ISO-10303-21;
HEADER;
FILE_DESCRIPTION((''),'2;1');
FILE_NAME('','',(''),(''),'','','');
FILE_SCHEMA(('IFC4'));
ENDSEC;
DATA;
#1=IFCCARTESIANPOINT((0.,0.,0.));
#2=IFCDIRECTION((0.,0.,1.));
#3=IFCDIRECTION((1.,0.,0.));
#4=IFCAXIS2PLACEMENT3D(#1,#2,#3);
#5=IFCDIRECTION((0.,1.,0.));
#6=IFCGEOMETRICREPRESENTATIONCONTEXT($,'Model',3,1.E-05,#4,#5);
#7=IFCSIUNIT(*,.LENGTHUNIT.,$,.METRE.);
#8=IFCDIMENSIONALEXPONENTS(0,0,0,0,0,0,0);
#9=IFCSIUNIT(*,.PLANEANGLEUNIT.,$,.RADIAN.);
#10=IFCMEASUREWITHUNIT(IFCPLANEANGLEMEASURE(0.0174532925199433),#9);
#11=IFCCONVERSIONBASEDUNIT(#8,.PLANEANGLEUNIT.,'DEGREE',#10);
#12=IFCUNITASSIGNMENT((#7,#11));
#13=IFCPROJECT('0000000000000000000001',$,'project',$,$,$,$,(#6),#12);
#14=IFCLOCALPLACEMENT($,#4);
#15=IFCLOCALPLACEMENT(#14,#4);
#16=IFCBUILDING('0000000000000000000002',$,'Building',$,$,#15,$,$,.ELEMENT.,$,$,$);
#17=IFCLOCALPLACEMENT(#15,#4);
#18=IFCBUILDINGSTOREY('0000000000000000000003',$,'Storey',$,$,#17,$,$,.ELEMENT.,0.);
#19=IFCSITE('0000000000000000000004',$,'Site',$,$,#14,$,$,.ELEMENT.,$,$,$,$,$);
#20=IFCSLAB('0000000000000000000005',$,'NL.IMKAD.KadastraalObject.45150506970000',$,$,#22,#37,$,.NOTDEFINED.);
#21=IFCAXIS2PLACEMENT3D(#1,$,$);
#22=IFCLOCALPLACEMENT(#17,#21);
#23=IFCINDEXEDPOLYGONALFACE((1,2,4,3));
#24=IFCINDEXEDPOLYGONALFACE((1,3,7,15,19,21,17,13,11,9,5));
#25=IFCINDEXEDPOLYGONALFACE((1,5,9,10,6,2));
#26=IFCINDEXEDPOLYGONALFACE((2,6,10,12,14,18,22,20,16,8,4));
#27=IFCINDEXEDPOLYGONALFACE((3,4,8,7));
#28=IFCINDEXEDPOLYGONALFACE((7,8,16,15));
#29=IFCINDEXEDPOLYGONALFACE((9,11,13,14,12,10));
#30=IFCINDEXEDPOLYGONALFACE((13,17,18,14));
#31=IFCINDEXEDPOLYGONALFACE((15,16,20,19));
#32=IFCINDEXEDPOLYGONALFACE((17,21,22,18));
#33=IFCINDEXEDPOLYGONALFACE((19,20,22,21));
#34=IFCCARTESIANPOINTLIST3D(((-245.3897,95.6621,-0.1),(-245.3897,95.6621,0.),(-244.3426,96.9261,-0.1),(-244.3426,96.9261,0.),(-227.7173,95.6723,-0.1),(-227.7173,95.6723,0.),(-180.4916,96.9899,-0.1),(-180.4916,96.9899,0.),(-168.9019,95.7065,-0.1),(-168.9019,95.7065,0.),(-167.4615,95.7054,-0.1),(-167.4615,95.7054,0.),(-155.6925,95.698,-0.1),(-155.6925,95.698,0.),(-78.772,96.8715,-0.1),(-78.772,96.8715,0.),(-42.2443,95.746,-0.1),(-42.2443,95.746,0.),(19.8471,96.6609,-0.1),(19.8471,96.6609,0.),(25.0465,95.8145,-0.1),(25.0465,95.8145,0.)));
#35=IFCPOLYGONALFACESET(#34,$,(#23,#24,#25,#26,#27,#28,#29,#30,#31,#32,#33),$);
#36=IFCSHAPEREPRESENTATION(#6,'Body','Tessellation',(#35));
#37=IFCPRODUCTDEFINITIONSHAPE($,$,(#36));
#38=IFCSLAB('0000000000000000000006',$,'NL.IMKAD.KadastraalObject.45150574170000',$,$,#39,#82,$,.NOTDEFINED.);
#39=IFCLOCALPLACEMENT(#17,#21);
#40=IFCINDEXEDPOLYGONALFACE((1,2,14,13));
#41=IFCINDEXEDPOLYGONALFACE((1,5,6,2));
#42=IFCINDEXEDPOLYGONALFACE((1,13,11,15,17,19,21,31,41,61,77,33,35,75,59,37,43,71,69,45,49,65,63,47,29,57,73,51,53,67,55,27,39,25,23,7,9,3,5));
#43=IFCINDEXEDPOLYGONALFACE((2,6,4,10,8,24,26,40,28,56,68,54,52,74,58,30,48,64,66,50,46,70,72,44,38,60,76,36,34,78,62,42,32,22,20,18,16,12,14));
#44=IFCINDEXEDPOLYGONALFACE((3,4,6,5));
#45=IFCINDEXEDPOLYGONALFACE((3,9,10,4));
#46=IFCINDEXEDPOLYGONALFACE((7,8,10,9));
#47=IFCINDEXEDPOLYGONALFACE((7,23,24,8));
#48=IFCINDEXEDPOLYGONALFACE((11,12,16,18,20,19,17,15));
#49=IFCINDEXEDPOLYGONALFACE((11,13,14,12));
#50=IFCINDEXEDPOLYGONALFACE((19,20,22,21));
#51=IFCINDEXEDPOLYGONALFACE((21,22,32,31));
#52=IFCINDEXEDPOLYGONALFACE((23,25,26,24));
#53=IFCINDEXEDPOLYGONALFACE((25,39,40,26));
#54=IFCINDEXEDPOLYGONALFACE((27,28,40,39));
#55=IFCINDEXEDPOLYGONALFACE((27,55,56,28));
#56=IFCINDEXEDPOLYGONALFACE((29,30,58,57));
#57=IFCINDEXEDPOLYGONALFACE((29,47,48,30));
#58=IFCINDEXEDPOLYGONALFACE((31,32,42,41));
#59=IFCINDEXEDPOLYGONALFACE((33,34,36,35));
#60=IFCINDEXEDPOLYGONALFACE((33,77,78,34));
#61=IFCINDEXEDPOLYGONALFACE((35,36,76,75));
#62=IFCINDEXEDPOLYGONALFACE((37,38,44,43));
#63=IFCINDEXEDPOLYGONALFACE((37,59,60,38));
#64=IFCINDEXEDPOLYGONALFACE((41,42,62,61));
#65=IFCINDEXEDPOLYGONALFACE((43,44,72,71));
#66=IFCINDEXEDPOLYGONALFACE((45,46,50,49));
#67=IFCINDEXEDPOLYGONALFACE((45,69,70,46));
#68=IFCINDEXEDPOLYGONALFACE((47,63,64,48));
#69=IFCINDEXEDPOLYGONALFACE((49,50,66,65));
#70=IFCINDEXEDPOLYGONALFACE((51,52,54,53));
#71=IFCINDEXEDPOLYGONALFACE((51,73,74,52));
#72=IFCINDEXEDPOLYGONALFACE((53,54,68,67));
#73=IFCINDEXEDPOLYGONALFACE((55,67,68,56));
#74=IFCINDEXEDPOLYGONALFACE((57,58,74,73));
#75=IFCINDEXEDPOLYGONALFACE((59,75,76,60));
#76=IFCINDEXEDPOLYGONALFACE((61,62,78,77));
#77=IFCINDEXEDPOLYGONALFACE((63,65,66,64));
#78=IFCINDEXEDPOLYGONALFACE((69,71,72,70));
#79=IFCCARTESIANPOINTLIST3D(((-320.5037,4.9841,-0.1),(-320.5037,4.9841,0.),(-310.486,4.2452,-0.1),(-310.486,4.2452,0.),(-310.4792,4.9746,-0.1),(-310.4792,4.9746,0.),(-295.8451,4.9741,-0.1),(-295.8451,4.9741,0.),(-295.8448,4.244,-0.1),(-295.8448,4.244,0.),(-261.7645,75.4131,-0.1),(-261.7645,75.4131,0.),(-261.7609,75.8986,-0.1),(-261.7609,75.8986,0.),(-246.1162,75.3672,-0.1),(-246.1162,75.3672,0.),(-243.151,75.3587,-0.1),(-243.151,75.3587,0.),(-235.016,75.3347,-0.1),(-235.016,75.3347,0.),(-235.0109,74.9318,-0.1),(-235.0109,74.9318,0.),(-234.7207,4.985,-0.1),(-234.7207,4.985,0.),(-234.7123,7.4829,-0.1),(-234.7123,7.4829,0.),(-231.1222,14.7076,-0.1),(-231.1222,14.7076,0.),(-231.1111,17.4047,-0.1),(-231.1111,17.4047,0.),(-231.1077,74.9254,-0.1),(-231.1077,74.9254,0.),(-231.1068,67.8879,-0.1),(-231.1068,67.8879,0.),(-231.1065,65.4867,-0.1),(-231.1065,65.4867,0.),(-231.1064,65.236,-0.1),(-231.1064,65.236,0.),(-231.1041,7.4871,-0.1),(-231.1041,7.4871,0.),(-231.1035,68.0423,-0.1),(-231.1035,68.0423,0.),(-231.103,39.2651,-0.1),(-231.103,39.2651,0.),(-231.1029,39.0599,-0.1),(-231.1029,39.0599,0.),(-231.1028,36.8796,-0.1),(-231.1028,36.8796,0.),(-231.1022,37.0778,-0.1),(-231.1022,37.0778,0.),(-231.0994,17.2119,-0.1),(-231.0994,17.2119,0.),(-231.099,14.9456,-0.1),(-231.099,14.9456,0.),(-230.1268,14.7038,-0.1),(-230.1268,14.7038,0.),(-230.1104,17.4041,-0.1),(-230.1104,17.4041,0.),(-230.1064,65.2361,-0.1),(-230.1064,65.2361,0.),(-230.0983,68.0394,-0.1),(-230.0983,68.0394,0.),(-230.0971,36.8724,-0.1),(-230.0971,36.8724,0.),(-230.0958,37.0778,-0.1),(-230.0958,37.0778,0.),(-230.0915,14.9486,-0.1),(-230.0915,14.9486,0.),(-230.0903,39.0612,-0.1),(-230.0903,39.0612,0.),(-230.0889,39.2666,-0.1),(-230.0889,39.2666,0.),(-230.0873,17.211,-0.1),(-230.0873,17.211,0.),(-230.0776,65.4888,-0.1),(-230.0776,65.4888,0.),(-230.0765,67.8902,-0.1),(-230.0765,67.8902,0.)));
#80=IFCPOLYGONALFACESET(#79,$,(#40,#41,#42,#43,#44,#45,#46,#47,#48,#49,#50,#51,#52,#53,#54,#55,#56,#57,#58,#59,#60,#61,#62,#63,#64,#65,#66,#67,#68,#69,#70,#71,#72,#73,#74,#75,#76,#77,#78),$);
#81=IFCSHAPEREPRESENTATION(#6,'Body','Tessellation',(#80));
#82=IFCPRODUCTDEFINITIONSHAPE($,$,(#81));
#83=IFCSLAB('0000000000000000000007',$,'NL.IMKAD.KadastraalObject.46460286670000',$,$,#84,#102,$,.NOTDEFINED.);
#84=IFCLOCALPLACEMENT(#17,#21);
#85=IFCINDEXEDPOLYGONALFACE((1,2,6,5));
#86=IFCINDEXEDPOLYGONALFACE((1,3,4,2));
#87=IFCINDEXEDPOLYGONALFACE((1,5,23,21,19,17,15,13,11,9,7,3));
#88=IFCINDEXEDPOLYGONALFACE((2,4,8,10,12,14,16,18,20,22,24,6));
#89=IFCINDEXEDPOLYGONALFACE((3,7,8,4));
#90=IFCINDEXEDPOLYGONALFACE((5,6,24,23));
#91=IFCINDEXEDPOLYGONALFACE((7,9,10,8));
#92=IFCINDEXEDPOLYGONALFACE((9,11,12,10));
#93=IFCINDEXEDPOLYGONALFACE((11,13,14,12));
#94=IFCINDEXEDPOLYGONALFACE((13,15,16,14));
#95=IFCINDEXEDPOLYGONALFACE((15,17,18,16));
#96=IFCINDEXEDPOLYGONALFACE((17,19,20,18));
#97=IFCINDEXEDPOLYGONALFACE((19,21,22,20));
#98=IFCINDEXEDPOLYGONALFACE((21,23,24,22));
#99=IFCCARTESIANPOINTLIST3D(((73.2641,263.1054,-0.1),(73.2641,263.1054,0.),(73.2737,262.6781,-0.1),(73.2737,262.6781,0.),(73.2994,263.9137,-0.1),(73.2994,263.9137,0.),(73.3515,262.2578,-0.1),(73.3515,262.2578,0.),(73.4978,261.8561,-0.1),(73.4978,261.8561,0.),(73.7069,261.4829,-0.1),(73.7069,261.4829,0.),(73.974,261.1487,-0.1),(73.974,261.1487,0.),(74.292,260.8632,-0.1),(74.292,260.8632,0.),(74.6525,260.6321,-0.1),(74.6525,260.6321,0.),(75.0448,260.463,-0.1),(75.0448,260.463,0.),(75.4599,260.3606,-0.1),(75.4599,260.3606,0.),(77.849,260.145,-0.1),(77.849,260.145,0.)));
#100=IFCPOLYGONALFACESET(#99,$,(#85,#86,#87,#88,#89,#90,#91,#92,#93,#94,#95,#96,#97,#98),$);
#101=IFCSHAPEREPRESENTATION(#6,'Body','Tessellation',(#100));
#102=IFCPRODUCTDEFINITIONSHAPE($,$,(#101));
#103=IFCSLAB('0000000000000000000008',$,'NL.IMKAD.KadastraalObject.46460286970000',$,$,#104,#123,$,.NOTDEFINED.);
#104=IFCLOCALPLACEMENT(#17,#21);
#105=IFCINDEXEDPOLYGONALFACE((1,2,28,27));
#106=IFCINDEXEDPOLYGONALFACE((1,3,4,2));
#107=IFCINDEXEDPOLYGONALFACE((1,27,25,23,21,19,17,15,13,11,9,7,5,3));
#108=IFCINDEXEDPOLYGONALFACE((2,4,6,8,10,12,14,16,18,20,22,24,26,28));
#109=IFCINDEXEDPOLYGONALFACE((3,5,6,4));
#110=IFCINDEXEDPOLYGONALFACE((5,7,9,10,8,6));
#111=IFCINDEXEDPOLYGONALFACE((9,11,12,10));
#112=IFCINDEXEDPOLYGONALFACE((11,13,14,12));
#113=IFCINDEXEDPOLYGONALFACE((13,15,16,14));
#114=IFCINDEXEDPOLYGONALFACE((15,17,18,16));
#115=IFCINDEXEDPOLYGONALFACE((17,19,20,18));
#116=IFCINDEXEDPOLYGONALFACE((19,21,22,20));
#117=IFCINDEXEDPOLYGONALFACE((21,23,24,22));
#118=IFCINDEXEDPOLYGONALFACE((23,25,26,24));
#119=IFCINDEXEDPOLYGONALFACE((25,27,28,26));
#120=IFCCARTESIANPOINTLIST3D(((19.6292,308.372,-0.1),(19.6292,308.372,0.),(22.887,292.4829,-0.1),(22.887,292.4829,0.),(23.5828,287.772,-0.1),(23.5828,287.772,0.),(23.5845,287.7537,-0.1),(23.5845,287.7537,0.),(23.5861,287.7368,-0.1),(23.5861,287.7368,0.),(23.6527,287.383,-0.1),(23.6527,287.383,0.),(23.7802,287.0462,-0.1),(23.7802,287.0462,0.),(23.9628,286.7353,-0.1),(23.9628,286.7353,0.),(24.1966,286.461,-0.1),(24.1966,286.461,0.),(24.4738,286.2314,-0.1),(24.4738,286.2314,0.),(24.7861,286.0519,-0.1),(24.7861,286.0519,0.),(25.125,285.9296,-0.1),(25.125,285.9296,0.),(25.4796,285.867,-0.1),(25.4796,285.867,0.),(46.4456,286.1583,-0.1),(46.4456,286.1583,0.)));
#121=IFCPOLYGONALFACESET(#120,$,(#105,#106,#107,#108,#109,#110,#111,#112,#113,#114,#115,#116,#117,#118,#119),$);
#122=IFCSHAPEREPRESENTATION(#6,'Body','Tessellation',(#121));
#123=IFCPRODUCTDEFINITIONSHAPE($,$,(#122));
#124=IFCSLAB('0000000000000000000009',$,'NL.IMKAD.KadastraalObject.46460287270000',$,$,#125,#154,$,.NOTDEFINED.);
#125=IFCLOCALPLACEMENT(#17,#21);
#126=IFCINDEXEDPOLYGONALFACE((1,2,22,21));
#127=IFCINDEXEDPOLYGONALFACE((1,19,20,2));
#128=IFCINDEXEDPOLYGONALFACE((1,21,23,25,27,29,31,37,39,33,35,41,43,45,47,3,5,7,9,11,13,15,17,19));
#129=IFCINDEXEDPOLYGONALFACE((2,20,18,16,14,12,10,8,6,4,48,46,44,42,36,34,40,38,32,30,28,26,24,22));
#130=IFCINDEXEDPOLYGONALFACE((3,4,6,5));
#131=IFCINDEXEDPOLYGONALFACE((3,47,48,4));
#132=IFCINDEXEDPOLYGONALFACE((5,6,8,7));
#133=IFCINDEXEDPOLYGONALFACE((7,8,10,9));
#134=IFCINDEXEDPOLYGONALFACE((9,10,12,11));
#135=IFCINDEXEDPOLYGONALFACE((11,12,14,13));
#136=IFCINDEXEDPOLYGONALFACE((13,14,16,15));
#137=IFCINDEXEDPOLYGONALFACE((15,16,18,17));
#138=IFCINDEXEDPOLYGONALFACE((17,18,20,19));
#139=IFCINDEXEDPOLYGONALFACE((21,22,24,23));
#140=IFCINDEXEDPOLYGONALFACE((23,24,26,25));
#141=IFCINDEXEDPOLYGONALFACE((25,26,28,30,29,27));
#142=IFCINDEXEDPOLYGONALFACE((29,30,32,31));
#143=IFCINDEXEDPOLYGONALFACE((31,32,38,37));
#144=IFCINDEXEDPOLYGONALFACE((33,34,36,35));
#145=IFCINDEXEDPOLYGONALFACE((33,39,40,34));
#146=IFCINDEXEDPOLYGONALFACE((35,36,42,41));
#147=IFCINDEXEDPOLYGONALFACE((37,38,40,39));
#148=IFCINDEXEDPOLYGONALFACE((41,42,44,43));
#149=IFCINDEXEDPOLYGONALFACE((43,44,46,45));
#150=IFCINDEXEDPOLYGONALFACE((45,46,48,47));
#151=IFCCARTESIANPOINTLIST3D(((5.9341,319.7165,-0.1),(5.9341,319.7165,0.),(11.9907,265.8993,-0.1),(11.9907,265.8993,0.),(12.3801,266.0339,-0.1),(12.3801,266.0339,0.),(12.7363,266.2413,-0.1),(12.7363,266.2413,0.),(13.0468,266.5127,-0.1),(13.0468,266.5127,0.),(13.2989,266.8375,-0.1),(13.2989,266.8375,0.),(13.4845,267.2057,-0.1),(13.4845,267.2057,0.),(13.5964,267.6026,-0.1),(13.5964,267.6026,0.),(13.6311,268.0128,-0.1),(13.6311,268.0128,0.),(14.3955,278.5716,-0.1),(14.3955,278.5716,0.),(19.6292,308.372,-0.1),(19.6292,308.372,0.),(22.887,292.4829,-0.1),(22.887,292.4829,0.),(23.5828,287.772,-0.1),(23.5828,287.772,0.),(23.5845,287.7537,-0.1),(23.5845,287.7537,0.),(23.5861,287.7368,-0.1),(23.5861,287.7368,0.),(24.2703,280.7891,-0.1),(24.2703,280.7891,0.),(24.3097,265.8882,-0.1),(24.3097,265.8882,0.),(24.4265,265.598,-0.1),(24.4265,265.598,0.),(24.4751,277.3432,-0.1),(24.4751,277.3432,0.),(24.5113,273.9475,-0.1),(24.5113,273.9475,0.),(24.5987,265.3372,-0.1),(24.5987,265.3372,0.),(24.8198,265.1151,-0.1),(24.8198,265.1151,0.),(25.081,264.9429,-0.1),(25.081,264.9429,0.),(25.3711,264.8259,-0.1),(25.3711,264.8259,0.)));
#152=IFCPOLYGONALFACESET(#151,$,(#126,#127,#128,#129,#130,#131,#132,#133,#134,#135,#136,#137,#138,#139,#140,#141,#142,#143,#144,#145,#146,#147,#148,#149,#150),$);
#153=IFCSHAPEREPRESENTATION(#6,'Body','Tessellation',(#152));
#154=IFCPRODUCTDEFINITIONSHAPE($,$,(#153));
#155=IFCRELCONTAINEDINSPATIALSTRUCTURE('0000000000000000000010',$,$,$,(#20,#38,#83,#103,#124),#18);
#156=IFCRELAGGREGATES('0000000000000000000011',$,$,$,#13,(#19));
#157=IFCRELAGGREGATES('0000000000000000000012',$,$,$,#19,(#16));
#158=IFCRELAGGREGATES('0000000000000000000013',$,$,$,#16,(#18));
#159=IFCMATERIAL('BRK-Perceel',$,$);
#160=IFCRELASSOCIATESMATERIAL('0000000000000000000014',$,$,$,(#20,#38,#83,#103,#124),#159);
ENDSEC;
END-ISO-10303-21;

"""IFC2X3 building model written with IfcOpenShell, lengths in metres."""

from ifc_helpers import new_model, entity, si_unit, converted_unit, direction, frame, origin_with_axes, place, context, project, spatial, polyline, outline, extrude, material, element, save


model = new_model("IFC2X3")

# Units and contexts
model_context = context("Model", 3, precision=1e-05, world=origin_with_axes(), true_north=direction((0.0, 1.0, 0.0)))
ifc_project = project(units=[si_unit("LENGTHUNIT", "METRE"), converted_unit("PLANEANGLEUNIT", "DEGREE", entity("IfcPlaneAngleMeasure", 0.0174532925199433), si_unit("PLANEANGLEUNIT", "RADIAN"), dimensions=[0, 0, 0, 0, 0, 0, 0])], contexts=[model_context])

# Site, building, storey
site_placement = place(None, origin_with_axes())
site = spatial("IfcSite", under=ifc_project, at=site_placement, Name="Site", CompositionType="ELEMENT")
building_placement = place(site_placement, origin_with_axes())
building = spatial("IfcBuilding", under=site, at=building_placement, Name="Building", CompositionType="ELEMENT")
storey_placement = place(building_placement, origin_with_axes())
storey = spatial("IfcBuildingStorey", under=building, at=storey_placement, Name="Storey", CompositionType="ELEMENT", Elevation=0.0)

# Slabs
ifc_material = material(Name="BRK-Perceel")
slab_1_placement = place(storey_placement, frame((0.0, 0.0, -0.1), z_axis=(0.0, 0.0, 1.0), x_axis=(1.0, 0.0, 0.0)))
element("IfcSlab", 1, at=slab_1_placement, inside=storey, material=ifc_material, Name="NL.IMKAD.KadastraalObject.45150506970000", PredefinedType="NOTDEFINED", context=model_context, shape_type="SweptSolid", body=[
    extrude(outline(polyline([(-180.4916, 96.9899), (-78.772, 96.8715), (19.8471, 96.6609), (25.0465, 95.8145), (-42.2443, 95.746), (-155.6925, 95.698), (-167.4615, 95.7054), (-168.9019, 95.7065), (-227.7173, 95.6723), (-245.3897, 95.6621), (-244.3426, 96.9261), (-180.4916, 96.9899)])), origin_with_axes(), (0.0, 0.0, 1.0), 0.1),
])
slab_2_placement = place(storey_placement, frame((0.0, 0.0, -0.1), z_axis=(0.0, 0.0, 1.0), x_axis=(1.0, 0.0, 0.0)))
element("IfcSlab", 2, at=slab_2_placement, inside=storey, material=ifc_material, Name="NL.IMKAD.KadastraalObject.45150574170000", PredefinedType="NOTDEFINED", context=model_context, shape_type="SweptSolid", body=[
    extrude(outline(polyline([(-261.7645, 75.4131), (-246.1162, 75.3672), (-243.151, 75.3587), (-235.016, 75.3347), (-235.0109, 74.9318), (-231.1077, 74.9254), (-231.1035, 68.0423), (-230.0983, 68.0394), (-230.0765, 67.8902), (-231.1068, 67.8879), (-231.1065, 65.4867), (-230.0776, 65.4888), (-230.1064, 65.2361), (-231.1064, 65.236), (-231.103, 39.2651), (-230.0889, 39.2666), (-230.0903, 39.0612), (-231.1029, 39.0599), (-231.1022, 37.0778), (-230.0958, 37.0778), (-230.0971, 36.8724), (-231.1028, 36.8796), (-231.1111, 17.4047), (-230.1104, 17.4041), (-230.0873, 17.211), (-231.0994, 17.2119), (-231.099, 14.9456), (-230.0915, 14.9486), (-230.1268, 14.7038), (-231.1222, 14.7076), (-231.1041, 7.4871), (-234.7123, 7.4829), (-234.7207, 4.985), (-295.8451, 4.9741), (-295.8448, 4.244), (-310.486, 4.2452), (-310.4792, 4.9746), (-320.5037, 4.9841), (-261.7609, 75.8986), (-261.7645, 75.4131)])), origin_with_axes(), (0.0, 0.0, 1.0), 0.1),
])
slab_3_placement = place(storey_placement, frame((0.0, 0.0, -0.1), z_axis=(0.0, 0.0, 1.0), x_axis=(1.0, 0.0, 0.0)))
element("IfcSlab", 3, at=slab_3_placement, inside=storey, material=ifc_material, Name="NL.IMKAD.KadastraalObject.46460286670000", PredefinedType="NOTDEFINED", context=model_context, shape_type="SweptSolid", body=[
    extrude(outline(polyline([(75.4599, 260.3606), (75.0448, 260.463), (74.6525, 260.6321), (74.292, 260.8632), (73.974, 261.1487), (73.7069, 261.4829), (73.4978, 261.8561), (73.3515, 262.2578), (73.2737, 262.6781), (73.2641, 263.1054), (73.2994, 263.9137), (77.849, 260.145), (75.4599, 260.3606)])), origin_with_axes(), (0.0, 0.0, 1.0), 0.1),
])
slab_4_placement = place(storey_placement, frame((0.0, 0.0, -0.1), z_axis=(0.0, 0.0, 1.0), x_axis=(1.0, 0.0, 0.0)))
element("IfcSlab", 4, at=slab_4_placement, inside=storey, material=ifc_material, Name="NL.IMKAD.KadastraalObject.46460286970000", PredefinedType="NOTDEFINED", context=model_context, shape_type="SweptSolid", body=[
    extrude(outline(polyline([(25.4796, 285.867), (25.125, 285.9296), (24.7861, 286.0519), (24.4738, 286.2314), (24.1966, 286.461), (23.9628, 286.7353), (23.7802, 287.0462), (23.6527, 287.383), (23.5861, 287.7368), (23.5845, 287.7537), (23.5828, 287.772), (22.887, 292.4829), (19.6292, 308.372), (46.4456, 286.1583), (25.4796, 285.867)])), origin_with_axes(), (0.0, 0.0, 1.0), 0.1),
])
slab_5_placement = place(storey_placement, frame((0.0, 0.0, -0.1), z_axis=(0.0, 0.0, 1.0), x_axis=(1.0, 0.0, 0.0)))
element("IfcSlab", 5, at=slab_5_placement, inside=storey, material=ifc_material, Name="NL.IMKAD.KadastraalObject.46460287270000", PredefinedType="NOTDEFINED", context=model_context, shape_type="SweptSolid", body=[
    extrude(outline(polyline([(22.887, 292.4829), (23.5828, 287.772), (23.5845, 287.7537), (23.5861, 287.7368), (24.2703, 280.7891), (24.4751, 277.3432), (24.5113, 273.9475), (24.3097, 265.8882), (24.4265, 265.598), (24.5987, 265.3372), (24.8198, 265.1151), (25.081, 264.9429), (25.3711, 264.8259), (11.9907, 265.8993), (12.3801, 266.0339), (12.7363, 266.2413), (13.0468, 266.5127), (13.2989, 266.8375), (13.4845, 267.2057), (13.5964, 267.6026), (13.6311, 268.0128), (14.3955, 278.5716), (5.9341, 319.7165), (19.6292, 308.372), (22.887, 292.4829)])), origin_with_axes(), (0.0, 0.0, 1.0), 0.1),
])

save(model, "model.ifc")
